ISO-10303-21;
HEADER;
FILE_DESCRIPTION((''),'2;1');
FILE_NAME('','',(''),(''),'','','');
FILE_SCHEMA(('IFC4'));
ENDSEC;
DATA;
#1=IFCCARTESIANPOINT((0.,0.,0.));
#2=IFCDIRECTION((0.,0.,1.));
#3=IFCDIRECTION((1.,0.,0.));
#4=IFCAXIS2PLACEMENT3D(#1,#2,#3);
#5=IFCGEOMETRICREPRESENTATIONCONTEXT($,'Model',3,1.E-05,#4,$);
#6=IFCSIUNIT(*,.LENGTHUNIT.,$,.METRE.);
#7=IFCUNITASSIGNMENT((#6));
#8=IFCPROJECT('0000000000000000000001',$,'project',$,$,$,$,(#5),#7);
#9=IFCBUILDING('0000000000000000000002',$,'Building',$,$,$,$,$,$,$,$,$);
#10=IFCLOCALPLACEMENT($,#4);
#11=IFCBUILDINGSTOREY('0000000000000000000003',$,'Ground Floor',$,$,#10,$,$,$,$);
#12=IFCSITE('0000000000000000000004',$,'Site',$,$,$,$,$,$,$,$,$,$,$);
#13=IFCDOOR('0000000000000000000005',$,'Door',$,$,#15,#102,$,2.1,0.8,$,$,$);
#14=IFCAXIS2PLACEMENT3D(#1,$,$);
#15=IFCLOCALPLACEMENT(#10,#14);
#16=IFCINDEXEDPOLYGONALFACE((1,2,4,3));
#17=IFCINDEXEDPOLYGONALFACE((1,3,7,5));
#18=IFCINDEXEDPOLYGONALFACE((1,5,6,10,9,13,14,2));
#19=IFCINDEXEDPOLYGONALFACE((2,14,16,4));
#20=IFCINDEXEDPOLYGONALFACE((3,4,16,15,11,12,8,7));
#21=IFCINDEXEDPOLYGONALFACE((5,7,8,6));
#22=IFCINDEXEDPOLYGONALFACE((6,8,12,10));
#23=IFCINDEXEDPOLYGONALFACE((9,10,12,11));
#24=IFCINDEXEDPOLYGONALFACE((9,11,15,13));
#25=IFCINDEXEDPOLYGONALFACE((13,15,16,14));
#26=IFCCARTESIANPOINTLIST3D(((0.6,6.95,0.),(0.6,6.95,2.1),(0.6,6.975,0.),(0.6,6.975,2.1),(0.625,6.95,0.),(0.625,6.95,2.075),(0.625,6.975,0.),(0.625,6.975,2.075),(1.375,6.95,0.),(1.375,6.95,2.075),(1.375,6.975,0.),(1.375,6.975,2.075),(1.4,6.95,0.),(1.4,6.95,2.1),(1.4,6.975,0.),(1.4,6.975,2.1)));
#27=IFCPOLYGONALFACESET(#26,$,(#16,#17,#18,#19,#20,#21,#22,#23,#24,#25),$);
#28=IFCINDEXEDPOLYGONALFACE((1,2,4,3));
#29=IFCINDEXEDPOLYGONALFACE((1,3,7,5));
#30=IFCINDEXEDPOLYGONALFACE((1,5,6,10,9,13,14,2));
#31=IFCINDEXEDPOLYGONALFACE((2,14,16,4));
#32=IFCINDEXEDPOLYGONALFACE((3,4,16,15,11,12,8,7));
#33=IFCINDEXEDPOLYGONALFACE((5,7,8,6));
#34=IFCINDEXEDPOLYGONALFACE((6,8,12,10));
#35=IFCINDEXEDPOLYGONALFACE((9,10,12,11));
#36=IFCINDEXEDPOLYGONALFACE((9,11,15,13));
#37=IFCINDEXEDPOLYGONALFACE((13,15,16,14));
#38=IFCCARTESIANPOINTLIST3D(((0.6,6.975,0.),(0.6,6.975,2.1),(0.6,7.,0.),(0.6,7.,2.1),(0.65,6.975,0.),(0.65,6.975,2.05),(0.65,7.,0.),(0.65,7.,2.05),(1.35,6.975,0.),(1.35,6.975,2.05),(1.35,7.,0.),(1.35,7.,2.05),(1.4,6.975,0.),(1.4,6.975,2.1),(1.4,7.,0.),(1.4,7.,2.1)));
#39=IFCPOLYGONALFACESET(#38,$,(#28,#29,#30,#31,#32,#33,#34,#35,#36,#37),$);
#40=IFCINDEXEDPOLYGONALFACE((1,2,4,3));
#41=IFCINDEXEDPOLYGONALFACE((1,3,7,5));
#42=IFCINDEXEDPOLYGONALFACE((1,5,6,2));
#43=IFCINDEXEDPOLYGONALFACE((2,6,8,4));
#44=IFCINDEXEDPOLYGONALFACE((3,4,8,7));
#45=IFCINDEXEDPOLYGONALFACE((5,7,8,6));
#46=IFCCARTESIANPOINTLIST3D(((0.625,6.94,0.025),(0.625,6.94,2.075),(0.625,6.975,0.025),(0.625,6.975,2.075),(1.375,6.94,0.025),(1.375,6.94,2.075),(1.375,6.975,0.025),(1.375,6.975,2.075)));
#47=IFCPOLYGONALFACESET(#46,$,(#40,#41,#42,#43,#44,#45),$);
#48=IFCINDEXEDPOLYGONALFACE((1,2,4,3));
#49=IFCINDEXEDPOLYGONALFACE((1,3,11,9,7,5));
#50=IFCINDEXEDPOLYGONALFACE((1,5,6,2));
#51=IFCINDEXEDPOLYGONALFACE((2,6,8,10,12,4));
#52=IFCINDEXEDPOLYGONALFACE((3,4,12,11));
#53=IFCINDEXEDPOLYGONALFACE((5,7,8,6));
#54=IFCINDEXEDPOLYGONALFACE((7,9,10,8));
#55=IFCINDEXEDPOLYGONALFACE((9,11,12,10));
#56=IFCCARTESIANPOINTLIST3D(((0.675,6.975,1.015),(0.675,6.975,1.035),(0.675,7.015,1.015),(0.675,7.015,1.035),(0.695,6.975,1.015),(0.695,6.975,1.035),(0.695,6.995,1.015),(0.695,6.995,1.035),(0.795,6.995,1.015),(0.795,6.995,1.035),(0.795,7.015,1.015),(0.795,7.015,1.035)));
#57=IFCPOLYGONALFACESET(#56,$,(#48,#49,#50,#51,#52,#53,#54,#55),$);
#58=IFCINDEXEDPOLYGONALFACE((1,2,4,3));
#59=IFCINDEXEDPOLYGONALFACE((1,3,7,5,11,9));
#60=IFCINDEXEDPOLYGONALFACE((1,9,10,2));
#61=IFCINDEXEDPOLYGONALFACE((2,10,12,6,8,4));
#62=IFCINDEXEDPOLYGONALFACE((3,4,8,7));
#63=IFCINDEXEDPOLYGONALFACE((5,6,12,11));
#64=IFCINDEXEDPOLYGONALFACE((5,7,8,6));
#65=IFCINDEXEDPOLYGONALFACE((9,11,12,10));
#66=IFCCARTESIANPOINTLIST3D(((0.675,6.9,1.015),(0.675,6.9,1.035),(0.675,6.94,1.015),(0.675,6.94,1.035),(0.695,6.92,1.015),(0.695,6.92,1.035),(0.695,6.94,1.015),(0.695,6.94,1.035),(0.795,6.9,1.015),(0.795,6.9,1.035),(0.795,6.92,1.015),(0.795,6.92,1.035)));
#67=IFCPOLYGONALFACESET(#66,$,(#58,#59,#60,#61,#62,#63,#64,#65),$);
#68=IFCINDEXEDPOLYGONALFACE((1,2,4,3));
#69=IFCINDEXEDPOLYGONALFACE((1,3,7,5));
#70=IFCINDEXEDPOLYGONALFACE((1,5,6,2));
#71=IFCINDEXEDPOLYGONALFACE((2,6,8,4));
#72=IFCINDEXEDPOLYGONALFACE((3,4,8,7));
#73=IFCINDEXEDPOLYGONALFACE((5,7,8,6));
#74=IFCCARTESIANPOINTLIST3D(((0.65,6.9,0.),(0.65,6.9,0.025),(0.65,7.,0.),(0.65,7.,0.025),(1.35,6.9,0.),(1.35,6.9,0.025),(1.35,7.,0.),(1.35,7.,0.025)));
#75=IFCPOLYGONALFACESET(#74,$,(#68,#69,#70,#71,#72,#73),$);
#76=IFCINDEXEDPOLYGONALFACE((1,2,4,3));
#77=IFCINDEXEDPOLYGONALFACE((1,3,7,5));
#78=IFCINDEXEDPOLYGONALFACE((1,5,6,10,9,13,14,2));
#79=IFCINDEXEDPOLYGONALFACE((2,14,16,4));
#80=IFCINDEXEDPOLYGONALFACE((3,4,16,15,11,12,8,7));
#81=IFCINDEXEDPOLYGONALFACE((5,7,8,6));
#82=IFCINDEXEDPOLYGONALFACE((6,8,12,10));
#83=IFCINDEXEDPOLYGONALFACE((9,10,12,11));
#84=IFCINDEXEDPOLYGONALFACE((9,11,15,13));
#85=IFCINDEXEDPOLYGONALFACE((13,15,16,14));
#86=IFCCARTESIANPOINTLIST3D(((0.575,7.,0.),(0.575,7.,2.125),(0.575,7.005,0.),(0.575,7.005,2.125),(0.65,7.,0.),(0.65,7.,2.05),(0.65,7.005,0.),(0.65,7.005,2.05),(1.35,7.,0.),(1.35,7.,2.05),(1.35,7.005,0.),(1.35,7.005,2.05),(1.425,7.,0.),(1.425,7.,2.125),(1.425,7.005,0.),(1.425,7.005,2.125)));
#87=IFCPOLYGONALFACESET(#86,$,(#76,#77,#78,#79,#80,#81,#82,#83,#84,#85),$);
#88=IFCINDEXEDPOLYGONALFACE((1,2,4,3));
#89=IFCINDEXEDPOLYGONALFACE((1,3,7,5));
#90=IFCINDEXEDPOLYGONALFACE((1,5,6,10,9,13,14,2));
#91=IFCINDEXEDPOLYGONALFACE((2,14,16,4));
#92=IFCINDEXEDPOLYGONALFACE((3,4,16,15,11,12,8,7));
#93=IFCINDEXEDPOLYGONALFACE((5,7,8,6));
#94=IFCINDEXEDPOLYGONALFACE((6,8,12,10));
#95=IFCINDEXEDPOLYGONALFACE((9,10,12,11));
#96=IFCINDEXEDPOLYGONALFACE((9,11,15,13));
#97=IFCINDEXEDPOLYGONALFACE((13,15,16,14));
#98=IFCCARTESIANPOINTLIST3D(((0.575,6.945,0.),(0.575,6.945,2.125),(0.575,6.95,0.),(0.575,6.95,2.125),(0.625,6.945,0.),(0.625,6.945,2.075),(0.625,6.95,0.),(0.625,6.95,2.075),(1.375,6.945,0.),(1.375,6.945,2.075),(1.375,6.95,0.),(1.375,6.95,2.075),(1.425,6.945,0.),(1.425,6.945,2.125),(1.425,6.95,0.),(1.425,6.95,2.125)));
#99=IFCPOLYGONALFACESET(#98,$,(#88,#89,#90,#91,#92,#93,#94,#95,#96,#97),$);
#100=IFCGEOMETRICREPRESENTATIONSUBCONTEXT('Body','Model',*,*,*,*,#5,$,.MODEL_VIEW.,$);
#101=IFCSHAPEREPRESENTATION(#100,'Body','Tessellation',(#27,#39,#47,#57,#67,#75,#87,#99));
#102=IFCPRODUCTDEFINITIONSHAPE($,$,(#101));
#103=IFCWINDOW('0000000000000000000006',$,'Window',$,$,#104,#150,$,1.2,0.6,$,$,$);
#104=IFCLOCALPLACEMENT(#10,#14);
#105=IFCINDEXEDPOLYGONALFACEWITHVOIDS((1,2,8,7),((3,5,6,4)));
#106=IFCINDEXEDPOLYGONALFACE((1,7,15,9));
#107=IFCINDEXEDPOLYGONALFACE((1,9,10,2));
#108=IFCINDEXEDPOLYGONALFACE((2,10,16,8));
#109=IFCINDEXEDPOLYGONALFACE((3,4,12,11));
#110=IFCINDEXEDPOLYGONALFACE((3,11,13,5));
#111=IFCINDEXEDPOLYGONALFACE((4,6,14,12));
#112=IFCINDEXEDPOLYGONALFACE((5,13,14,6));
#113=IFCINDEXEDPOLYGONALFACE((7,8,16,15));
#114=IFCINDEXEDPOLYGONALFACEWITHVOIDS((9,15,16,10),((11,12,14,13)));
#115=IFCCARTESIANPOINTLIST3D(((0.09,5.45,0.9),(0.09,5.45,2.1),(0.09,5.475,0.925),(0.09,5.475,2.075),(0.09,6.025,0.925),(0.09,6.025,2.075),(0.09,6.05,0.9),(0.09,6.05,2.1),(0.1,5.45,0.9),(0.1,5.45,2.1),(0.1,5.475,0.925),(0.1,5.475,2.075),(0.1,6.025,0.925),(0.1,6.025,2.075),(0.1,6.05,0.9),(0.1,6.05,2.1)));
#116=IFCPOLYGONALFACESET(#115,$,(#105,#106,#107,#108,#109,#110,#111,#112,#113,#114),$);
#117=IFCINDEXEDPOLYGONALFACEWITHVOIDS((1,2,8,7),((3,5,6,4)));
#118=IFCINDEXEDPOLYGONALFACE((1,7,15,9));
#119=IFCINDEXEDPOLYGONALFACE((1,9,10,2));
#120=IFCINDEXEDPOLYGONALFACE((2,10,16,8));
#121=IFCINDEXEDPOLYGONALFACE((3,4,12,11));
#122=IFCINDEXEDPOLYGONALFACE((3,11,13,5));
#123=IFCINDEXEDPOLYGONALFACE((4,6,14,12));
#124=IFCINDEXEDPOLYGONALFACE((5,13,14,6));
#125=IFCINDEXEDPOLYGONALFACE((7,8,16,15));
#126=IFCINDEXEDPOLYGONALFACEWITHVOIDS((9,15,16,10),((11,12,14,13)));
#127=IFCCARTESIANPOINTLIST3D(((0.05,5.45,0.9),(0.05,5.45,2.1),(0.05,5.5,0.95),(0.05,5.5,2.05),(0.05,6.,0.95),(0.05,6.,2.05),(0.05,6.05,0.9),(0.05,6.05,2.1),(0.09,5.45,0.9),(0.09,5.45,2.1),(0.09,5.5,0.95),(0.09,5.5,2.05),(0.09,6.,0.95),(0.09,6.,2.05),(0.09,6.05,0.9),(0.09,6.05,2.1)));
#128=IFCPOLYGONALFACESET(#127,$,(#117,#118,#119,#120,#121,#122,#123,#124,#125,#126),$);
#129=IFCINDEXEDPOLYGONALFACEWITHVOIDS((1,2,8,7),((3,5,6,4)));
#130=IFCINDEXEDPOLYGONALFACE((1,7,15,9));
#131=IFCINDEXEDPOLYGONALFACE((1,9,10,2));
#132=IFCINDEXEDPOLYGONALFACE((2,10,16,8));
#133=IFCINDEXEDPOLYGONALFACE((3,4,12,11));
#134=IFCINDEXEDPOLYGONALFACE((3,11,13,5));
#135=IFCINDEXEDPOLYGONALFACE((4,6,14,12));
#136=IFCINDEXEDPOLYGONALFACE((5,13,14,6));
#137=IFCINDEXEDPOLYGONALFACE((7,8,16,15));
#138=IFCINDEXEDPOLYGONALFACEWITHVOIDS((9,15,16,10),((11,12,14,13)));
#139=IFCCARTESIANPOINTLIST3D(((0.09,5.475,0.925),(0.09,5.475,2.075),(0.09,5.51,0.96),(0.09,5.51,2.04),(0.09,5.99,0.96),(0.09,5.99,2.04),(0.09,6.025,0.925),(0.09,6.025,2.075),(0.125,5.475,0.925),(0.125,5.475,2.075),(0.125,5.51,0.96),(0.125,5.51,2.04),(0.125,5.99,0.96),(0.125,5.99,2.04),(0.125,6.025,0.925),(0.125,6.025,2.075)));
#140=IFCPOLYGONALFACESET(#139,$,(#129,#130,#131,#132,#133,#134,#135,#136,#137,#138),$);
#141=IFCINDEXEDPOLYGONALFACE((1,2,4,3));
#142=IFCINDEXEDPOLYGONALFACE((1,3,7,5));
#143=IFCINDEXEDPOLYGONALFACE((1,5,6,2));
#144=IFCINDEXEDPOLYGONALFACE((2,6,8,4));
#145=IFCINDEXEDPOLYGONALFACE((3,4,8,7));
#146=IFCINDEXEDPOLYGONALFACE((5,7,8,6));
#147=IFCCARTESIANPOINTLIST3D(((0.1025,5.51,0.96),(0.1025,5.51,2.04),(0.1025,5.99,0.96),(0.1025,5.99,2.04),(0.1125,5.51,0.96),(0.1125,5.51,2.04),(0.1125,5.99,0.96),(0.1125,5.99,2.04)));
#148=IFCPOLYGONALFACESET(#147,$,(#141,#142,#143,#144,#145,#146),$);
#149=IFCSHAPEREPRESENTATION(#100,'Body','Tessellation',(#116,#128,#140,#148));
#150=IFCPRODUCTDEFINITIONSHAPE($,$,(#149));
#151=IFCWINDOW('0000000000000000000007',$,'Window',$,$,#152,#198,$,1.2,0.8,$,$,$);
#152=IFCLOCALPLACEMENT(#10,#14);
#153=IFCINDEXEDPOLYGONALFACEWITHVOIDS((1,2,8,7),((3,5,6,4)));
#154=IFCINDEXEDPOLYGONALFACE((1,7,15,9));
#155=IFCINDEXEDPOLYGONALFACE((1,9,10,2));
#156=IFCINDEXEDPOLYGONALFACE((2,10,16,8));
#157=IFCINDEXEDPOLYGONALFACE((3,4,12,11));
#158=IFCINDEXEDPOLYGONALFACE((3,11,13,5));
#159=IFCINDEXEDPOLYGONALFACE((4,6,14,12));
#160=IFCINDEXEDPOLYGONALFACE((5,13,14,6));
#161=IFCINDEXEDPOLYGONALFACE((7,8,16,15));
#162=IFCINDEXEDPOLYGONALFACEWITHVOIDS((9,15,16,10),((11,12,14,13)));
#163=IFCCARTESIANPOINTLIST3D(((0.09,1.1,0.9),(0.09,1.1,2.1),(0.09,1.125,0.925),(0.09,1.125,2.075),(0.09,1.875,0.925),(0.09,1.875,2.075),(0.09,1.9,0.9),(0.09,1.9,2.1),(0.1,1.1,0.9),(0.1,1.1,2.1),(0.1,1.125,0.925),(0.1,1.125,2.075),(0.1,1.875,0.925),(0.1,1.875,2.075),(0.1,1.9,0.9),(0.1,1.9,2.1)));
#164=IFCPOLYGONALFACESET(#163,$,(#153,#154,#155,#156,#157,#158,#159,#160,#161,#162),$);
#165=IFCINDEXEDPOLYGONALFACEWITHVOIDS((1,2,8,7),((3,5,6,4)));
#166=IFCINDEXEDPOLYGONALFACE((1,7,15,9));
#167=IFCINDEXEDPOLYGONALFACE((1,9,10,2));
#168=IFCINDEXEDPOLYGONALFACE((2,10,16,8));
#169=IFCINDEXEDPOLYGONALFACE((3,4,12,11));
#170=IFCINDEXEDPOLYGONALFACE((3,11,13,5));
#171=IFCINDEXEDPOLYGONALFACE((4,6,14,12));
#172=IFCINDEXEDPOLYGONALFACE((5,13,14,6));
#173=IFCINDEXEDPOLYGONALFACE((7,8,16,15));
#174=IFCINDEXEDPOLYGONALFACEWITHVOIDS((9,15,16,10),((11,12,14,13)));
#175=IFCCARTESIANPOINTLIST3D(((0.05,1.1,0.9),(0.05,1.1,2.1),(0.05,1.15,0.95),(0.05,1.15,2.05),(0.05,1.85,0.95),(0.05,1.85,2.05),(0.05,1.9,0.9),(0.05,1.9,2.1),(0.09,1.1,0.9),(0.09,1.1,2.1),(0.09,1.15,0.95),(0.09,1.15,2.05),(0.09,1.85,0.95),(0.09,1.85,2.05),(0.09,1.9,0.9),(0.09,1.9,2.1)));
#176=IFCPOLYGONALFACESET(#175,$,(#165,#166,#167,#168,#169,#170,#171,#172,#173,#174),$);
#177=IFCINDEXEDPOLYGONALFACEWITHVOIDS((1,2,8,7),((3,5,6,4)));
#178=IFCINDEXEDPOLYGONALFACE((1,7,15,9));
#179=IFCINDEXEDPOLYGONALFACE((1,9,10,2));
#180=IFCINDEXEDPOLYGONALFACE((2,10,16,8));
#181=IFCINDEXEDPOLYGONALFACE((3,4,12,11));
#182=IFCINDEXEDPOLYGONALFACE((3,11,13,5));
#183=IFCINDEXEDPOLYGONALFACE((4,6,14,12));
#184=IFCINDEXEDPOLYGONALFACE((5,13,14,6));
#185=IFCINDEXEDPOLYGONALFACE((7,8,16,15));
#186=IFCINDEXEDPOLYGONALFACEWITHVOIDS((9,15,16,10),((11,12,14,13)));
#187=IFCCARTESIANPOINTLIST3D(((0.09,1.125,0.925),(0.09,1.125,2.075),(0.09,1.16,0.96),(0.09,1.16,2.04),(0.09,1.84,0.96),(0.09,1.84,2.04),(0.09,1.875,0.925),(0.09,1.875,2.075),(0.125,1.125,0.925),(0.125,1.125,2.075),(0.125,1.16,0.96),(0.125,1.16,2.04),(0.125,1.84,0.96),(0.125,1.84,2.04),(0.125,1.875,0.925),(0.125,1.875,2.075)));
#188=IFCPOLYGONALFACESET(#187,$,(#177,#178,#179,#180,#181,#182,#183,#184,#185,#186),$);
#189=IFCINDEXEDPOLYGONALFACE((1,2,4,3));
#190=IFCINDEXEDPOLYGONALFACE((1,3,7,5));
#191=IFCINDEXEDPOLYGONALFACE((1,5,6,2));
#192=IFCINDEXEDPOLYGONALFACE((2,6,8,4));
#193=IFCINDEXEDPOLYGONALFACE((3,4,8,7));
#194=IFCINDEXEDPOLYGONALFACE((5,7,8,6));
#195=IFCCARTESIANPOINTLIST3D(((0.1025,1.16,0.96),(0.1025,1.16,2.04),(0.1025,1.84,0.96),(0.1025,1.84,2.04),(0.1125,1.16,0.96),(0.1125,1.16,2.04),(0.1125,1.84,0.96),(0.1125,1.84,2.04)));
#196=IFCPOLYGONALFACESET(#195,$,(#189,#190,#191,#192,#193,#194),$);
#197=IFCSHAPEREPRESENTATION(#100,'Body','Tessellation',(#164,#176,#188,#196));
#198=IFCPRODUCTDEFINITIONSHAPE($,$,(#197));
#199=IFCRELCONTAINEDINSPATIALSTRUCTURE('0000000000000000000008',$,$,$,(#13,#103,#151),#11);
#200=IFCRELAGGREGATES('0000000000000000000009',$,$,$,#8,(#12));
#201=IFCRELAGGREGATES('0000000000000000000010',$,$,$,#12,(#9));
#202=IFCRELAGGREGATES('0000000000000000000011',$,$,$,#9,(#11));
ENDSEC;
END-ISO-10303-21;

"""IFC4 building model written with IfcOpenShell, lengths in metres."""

from ifc_helpers import new_model, si_unit, frame, origin_with_axes, place, context, subcontext, project, spatial, line, indexed_curve, outline, extrude, element, save


model = new_model("IFC4")

# Units and contexts
model_context = context("Model", 3, precision=1e-05, world=origin_with_axes())
body_context = subcontext(model_context, "Body", "Model", "MODEL_VIEW")
ifc_project = project(units=[si_unit("LENGTHUNIT", "METRE")], contexts=[model_context])

# Site, building, storey
site = spatial("IfcSite", under=ifc_project, Name="Site")
building = spatial("IfcBuilding", under=site, Name="Building")
storey_placement = place(None, origin_with_axes())
storey = spatial("IfcBuildingStorey", under=building, at=storey_placement, Name="Ground Floor")

# Door
door_1_placement = place(storey_placement, frame((1.4, 7.0, 0.0), z_axis=(0.0, 0.0, 1.0), x_axis=(-1.0, 0.0, 0.0)))
element("IfcDoor", 1, at=door_1_placement, inside=storey, Name="Door", OverallHeight=2.1, OverallWidth=0.8, context=body_context, shape_type="SweptSolid", body=[
    extrude(outline(indexed_curve([(0.0, 0.0), (0.0, 2.1), (0.8, 2.1), (0.8, 0.0), (0.775, 0.0), (0.775, 2.075), (0.025, 2.075), (0.025, 0.0)], segments=[line(1, 2, 3, 4, 5, 6, 7, 8, 1)])), frame((0.0, 0.025, 0.0), z_axis=(0.0, -1.0, 0.0), x_axis=(1.0, 0.0, 0.0)), (0.0, 0.0, -1.0), 0.025),
    extrude(outline(indexed_curve([(0.0, 0.0), (0.0, 2.1), (0.8, 2.1), (0.8, 0.0), (0.75, 0.0), (0.75, 2.05), (0.05, 2.05), (0.05, 0.0)], segments=[line(1, 2, 3, 4, 5, 6, 7, 8, 1)])), frame((0.0, 0.0, 0.0), z_axis=(0.0, -1.0, 0.0), x_axis=(1.0, 0.0, 0.0)), (0.0, 0.0, -1.0), 0.025),
    extrude(outline(indexed_curve([(0.0, 0.0), (0.75, 0.0), (0.75, 0.035), (0.0, 0.035)], segments=[line(1, 2, 3, 4, 1)])), frame((0.025, 0.025, 0.025), z_axis=(0.0, 0.0, 1.0), x_axis=(1.0, 0.0, 0.0)), (0.0, 0.0, 1.0), 2.05),
    extrude(outline(indexed_curve([(0.0, 0.0), (0.0, -0.04), (-0.12, -0.04), (-0.12, -0.02), (-0.02, -0.02), (-0.02, 0.0)], segments=[line(1, 2, 3, 4, 5, 6, 1)])), frame((0.725, 0.025, 1.015), z_axis=(0.0, 0.0, 1.0), x_axis=(1.0, 0.0, 0.0)), (0.0, 0.0, 1.0), 0.02),
    extrude(outline(indexed_curve([(0.0, 0.0), (0.0, 0.04), (-0.12, 0.04), (-0.12, 0.02), (-0.02, 0.02), (-0.02, 0.0)], segments=[line(1, 2, 3, 4, 5, 6, 1)])), frame((0.725, 0.06, 1.015), z_axis=(0.0, 0.0, 1.0), x_axis=(1.0, 0.0, 0.0)), (0.0, 0.0, 1.0), 0.02),
    extrude(outline(indexed_curve([(0.0, 0.0), (0.7, 0.0), (0.7, 0.1), (0.0, 0.1)], segments=[line(1, 2, 3, 4, 1)])), frame((0.05, 0.0, 0.0), z_axis=(0.0, 0.0, 1.0), x_axis=(1.0, 0.0, 0.0)), (0.0, 0.0, 1.0), 0.025),
    extrude(outline(indexed_curve([(0.0, 0.0), (0.0, 2.125), (0.85, 2.125), (0.85, 0.0), (0.775, 0.0), (0.775, 2.05), (0.075, 2.05), (0.075, 0.0)], segments=[line(1, 2, 3, 4, 5, 6, 7, 8, 1)])), frame((-0.025, -0.005, 0.0), z_axis=(0.0, -1.0, 0.0), x_axis=(1.0, 0.0, 0.0)), (0.0, 0.0, -1.0), 0.005),
    extrude(outline(indexed_curve([(0.0, 0.0), (0.0, 2.125), (0.85, 2.125), (0.85, 0.0), (0.8, 0.0), (0.8, 2.075), (0.05, 2.075), (0.05, 0.0)], segments=[line(1, 2, 3, 4, 5, 6, 7, 8, 1)])), frame((-0.025, 0.05, 0.0), z_axis=(0.0, -1.0, 0.0), x_axis=(1.0, 0.0, 0.0)), (0.0, 0.0, -1.0), 0.005),
])

# Windows
window_1_placement = place(storey_placement, frame((0.0, 6.05, 0.9), z_axis=(0.0, 0.0, 1.0), x_axis=(0.0, -1.0, 0.0)))
element("IfcWindow", 2, at=window_1_placement, inside=storey, Name="Window", OverallHeight=1.2, OverallWidth=0.6, context=body_context, shape_type="SweptSolid", body=[
    extrude(outline(indexed_curve([(0.0, 0.0), (0.6, 0.0), (0.6, 1.2), (0.0, 1.2)], segments=[line(1, 2, 3, 4, 1)]), holes=[indexed_curve([(0.025, 0.025), (0.575, 0.025), (0.575, 1.175), (0.025, 1.175)], segments=[line(1, 2, 3, 4, 1)])]), frame((0.0, 0.09, 0.0), z_axis=(0.0, -1.0, 0.0), x_axis=(1.0, 0.0, 0.0)), (0.0, 0.0, -1.0), 0.01),
    extrude(outline(indexed_curve([(0.0, 0.0), (0.6, 0.0), (0.6, 1.2), (0.0, 1.2)], segments=[line(1, 2, 3, 4, 1)]), holes=[indexed_curve([(0.05, 0.05), (0.55, 0.05), (0.55, 1.15), (0.05, 1.15)], segments=[line(1, 2, 3, 4, 1)])]), frame((0.0, 0.05, 0.0), z_axis=(0.0, -1.0, 0.0), x_axis=(1.0, 0.0, 0.0)), (0.0, 0.0, -1.0), 0.04),
    extrude(outline(indexed_curve([(0.0, 0.0), (0.55, 0.0), (0.55, 1.15), (0.0, 1.15)], segments=[line(1, 2, 3, 4, 1)]), holes=[indexed_curve([(0.035, 0.035), (0.515, 0.035), (0.515, 1.115), (0.035, 1.115)], segments=[line(1, 2, 3, 4, 1)])]), frame((0.025, 0.09, 0.025), z_axis=(0.0, -1.0, 0.0), x_axis=(1.0, 0.0, 0.0)), (0.0, 0.0, -1.0), 0.035),
    extrude(outline(indexed_curve([(0.035, 0.035), (0.515, 0.035), (0.515, 1.115), (0.035, 1.115)], segments=[line(1, 2, 3, 4, 1)])), frame((0.025, 0.1025, 0.025), z_axis=(0.0, -1.0, 0.0), x_axis=(1.0, 0.0, 0.0)), (0.0, 0.0, -1.0), 0.01),
])
window_2_placement = place(storey_placement, frame((0.0, 1.9, 0.9), z_axis=(0.0, 0.0, 1.0), x_axis=(0.0, -1.0, 0.0)))
element("IfcWindow", 3, at=window_2_placement, inside=storey, Name="Window", OverallHeight=1.2, OverallWidth=0.8, context=body_context, shape_type="SweptSolid", body=[
    extrude(outline(indexed_curve([(0.0, 0.0), (0.8, 0.0), (0.8, 1.2), (0.0, 1.2)], segments=[line(1, 2, 3, 4, 1)]), holes=[indexed_curve([(0.025, 0.025), (0.775, 0.025), (0.775, 1.175), (0.025, 1.175)], segments=[line(1, 2, 3, 4, 1)])]), frame((0.0, 0.09, 0.0), z_axis=(0.0, -1.0, 0.0), x_axis=(1.0, 0.0, 0.0)), (0.0, 0.0, -1.0), 0.01),
    extrude(outline(indexed_curve([(0.0, 0.0), (0.8, 0.0), (0.8, 1.2), (0.0, 1.2)], segments=[line(1, 2, 3, 4, 1)]), holes=[indexed_curve([(0.05, 0.05), (0.75, 0.05), (0.75, 1.15), (0.05, 1.15)], segments=[line(1, 2, 3, 4, 1)])]), frame((0.0, 0.05, 0.0), z_axis=(0.0, -1.0, 0.0), x_axis=(1.0, 0.0, 0.0)), (0.0, 0.0, -1.0), 0.04),
    extrude(outline(indexed_curve([(0.0, 0.0), (0.75, 0.0), (0.75, 1.15), (0.0, 1.15)], segments=[line(1, 2, 3, 4, 1)]), holes=[indexed_curve([(0.035, 0.035), (0.715, 0.035), (0.715, 1.115), (0.035, 1.115)], segments=[line(1, 2, 3, 4, 1)])]), frame((0.025, 0.09, 0.025), z_axis=(0.0, -1.0, 0.0), x_axis=(1.0, 0.0, 0.0)), (0.0, 0.0, -1.0), 0.035),
    extrude(outline(indexed_curve([(0.035, 0.035), (0.715, 0.035), (0.715, 1.115), (0.035, 1.115)], segments=[line(1, 2, 3, 4, 1)])), frame((0.025, 0.1025, 0.025), z_axis=(0.0, -1.0, 0.0), x_axis=(1.0, 0.0, 0.0)), (0.0, 0.0, -1.0), 0.01),
])

save(model, "model.ifc")
